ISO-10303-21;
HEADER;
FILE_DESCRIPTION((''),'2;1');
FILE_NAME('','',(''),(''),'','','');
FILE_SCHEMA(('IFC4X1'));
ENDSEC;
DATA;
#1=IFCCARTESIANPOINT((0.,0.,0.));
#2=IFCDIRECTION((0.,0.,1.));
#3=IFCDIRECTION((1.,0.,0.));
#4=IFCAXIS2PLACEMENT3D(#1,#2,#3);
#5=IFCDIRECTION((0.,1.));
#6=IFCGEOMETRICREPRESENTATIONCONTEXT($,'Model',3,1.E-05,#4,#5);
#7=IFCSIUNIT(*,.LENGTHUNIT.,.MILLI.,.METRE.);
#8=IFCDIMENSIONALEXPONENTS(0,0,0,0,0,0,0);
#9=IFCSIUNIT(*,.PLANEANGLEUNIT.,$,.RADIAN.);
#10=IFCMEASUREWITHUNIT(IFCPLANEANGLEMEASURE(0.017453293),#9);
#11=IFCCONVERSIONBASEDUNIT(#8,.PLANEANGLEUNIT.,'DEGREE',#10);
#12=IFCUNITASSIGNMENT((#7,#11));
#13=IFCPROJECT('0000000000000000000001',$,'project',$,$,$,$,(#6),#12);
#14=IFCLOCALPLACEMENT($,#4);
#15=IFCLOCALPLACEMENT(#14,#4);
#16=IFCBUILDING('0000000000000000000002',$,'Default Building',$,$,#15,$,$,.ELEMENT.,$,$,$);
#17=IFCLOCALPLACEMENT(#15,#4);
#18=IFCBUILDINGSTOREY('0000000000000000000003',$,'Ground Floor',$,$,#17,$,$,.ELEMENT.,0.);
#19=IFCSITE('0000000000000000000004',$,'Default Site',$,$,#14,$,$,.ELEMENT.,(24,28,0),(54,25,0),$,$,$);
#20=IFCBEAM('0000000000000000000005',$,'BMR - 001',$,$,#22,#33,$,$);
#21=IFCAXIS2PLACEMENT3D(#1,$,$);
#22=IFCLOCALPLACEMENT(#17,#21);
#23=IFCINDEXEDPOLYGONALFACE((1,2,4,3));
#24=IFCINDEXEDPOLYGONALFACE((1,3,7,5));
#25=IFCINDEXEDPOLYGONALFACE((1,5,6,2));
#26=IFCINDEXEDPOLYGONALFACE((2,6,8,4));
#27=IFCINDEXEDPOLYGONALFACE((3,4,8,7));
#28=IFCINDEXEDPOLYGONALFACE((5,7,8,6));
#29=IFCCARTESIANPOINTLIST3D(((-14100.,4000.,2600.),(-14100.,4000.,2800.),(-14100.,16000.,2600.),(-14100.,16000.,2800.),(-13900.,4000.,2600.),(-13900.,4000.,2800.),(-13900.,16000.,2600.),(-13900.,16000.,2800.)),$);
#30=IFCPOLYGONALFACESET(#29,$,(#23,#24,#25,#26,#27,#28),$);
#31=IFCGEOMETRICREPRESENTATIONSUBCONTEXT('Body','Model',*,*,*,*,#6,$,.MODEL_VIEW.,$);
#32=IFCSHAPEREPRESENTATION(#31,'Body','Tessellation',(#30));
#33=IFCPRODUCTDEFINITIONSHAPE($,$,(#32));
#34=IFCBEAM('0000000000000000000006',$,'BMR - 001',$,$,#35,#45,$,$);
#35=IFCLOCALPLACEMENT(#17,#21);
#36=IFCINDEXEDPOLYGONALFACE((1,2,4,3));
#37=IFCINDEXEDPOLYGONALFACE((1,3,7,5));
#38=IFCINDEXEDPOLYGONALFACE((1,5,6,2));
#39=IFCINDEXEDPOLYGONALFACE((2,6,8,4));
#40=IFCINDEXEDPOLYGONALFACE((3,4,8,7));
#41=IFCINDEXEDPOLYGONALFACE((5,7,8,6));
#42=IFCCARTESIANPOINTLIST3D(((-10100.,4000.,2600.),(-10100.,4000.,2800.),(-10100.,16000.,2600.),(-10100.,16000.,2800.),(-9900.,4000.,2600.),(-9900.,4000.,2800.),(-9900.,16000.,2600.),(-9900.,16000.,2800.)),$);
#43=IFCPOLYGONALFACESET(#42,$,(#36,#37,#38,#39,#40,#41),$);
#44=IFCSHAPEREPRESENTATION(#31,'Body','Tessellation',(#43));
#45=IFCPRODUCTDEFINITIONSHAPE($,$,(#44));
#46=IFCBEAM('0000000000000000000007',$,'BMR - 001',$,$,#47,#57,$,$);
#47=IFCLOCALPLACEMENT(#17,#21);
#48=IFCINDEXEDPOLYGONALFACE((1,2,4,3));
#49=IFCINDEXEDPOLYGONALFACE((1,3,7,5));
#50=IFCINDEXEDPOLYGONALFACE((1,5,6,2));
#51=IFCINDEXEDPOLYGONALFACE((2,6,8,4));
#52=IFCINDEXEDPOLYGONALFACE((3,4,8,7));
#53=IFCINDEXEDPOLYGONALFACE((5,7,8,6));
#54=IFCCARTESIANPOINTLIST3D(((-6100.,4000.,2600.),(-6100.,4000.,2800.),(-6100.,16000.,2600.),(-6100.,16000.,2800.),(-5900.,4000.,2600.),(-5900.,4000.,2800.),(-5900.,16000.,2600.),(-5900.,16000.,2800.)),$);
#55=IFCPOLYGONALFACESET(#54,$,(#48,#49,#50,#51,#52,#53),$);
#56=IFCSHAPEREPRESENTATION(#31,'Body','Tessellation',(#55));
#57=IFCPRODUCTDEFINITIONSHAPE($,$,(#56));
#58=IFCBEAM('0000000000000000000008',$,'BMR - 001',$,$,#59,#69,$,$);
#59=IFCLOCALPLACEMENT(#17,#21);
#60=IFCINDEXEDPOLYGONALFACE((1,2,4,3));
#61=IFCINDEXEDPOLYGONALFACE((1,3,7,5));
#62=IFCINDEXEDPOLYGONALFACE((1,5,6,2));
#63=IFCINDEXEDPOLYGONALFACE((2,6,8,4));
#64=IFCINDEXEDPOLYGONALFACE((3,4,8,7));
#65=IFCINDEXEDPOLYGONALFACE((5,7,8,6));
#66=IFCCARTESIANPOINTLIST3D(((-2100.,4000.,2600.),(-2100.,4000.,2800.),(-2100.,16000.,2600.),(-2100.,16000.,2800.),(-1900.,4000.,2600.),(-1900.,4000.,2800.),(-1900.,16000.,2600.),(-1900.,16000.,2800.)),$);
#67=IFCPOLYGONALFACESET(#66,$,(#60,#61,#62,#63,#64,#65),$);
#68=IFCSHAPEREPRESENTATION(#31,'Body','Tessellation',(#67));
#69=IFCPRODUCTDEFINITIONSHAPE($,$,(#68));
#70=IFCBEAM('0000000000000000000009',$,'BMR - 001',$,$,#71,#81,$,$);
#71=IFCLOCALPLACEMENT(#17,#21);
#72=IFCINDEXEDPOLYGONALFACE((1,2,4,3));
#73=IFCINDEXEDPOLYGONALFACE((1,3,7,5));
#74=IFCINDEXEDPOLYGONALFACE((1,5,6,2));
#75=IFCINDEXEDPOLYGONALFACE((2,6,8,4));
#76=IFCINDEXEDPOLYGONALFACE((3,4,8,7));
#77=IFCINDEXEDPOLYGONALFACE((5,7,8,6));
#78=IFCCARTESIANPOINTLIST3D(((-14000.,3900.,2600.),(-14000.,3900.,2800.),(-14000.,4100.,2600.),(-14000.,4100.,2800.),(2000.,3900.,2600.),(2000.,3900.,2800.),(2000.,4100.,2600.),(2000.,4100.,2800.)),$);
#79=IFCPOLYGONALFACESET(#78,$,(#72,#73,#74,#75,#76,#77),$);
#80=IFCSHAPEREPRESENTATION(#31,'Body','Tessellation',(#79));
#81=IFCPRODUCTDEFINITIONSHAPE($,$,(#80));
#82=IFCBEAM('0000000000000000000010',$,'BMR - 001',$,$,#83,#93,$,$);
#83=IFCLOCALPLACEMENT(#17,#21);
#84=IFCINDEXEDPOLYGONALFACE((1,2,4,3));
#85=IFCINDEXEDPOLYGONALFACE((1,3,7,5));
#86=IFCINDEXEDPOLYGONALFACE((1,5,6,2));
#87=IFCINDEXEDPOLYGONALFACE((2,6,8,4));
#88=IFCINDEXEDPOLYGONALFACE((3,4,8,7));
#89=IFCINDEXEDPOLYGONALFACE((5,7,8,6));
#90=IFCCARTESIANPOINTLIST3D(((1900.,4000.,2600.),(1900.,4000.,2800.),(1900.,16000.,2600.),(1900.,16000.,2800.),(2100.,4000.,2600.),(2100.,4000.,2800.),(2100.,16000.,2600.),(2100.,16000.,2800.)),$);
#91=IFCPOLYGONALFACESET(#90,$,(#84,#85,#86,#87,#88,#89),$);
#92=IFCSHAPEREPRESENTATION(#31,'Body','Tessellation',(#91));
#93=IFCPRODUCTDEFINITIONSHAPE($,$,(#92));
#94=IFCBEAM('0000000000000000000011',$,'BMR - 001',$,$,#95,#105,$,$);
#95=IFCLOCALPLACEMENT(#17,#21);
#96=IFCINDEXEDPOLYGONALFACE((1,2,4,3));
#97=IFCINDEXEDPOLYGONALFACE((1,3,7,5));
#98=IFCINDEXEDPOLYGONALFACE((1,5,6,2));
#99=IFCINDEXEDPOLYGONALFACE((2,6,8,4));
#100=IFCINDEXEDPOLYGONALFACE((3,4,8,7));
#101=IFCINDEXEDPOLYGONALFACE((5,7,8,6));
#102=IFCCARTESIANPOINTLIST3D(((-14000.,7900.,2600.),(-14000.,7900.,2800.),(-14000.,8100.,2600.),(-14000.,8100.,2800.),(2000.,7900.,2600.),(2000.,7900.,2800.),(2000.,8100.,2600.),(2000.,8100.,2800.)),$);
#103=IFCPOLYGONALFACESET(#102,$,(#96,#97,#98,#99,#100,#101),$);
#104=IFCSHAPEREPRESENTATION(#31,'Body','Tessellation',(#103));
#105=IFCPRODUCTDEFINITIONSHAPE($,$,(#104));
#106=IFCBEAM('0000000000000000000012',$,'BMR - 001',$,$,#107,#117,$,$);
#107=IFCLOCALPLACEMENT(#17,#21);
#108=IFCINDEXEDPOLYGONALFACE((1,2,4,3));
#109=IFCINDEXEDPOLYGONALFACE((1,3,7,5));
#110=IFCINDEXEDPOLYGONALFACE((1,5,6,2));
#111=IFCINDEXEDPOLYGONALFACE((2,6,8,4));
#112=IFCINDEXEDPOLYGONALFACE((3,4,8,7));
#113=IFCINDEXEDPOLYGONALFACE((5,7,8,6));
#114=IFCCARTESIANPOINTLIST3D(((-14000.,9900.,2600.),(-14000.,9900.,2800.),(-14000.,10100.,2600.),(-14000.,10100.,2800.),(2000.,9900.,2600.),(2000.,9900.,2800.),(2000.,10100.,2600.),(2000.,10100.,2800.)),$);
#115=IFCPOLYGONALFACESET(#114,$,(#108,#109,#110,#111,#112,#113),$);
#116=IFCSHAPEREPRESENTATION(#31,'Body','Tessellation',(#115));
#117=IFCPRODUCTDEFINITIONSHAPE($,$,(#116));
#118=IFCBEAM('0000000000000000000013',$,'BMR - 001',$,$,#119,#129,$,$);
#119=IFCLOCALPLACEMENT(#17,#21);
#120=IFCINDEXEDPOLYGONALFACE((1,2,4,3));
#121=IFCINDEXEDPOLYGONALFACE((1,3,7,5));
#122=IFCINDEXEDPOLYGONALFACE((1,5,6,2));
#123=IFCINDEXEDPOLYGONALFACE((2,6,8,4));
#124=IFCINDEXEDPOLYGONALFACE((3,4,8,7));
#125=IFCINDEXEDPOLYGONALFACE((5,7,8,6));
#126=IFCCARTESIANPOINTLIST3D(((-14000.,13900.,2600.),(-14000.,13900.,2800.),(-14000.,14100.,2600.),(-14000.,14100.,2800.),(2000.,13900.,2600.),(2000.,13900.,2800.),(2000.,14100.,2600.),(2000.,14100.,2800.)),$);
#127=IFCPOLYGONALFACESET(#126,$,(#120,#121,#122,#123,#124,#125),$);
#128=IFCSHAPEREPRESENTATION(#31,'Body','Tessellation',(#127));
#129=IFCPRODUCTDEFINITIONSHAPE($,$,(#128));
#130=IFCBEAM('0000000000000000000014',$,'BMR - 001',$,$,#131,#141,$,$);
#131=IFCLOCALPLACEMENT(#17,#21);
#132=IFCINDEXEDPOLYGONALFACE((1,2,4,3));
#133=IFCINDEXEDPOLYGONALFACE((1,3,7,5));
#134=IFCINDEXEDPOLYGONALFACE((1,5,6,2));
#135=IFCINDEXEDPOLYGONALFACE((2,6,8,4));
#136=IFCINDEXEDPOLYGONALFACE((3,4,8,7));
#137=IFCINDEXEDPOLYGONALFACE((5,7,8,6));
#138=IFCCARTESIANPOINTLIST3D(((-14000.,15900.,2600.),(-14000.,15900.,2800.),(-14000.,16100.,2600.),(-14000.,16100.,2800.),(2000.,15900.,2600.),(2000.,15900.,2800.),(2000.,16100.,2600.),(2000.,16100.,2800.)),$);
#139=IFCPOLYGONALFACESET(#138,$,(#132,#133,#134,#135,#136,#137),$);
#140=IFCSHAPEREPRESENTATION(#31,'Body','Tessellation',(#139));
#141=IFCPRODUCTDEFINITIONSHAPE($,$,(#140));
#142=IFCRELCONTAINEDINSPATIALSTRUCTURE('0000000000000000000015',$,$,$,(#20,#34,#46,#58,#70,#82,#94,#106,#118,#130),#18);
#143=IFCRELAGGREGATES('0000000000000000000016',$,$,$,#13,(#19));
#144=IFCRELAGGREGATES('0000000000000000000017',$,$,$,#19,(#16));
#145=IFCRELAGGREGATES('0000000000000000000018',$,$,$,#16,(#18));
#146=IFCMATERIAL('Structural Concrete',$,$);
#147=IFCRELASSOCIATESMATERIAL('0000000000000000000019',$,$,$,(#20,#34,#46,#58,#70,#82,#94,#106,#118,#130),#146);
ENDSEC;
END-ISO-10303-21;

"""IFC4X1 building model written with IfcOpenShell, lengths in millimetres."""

from ifc_helpers import new_model, entity, si_unit, converted_unit, direction, frame, frame_2d, origin_with_axes, place, context, subcontext, project, spatial, rectangle, extrude, material, element, save


model = new_model("IFC4X1")

# Units and contexts
model_context = context("Model", 3, precision=1e-05, world=origin_with_axes(), true_north=direction((0.0, 1.0)))
body_context = subcontext(model_context, "Body", "Model", "MODEL_VIEW")
ifc_project = project(units=[si_unit("LENGTHUNIT", "METRE", prefix="MILLI"), converted_unit("PLANEANGLEUNIT", "DEGREE", entity("IfcPlaneAngleMeasure", 0.017453293), si_unit("PLANEANGLEUNIT", "RADIAN"), dimensions=[0, 0, 0, 0, 0, 0, 0])], contexts=[model_context])

# Site, building, storey
site_placement = place(None, origin_with_axes())
site = spatial("IfcSite", under=ifc_project, at=site_placement, Name="Default Site", CompositionType="ELEMENT", RefLatitude=(24, 28, 0), RefLongitude=(54, 25, 0))
building_placement = place(site_placement, origin_with_axes())
building = spatial("IfcBuilding", under=site, at=building_placement, Name="Default Building", CompositionType="ELEMENT")
storey_placement = place(building_placement, origin_with_axes())
storey = spatial("IfcBuildingStorey", under=building, at=storey_placement, Name="Ground Floor", CompositionType="ELEMENT", Elevation=0.0)

# Beams
ifc_material = material(Name="Structural Concrete")
for number, where, z_axis, x_axis, name in (
    (1, (-14000.0, 4000.0, 2800.0), (0.0, 0.0, 1.0), (1.0, 0.0, 0.0), "BMR - 001"),
    (2, (-10000.0, 4000.0, 2800.0), (0.0, 0.0, 1.0), (1.0, 0.0, 0.0), "BMR - 001"),
    (3, (-6000.0, 4000.0, 2800.0), (0.0, 0.0, 1.0), (1.0, 0.0, 0.0), "BMR - 001"),
    (4, (-2000.0, 4000.0, 2800.0), (0.0, 0.0, 1.0), (1.0, 0.0, 0.0), "BMR - 001"),
):
    element("IfcBeam", number, at=place(storey_placement, frame(where, z_axis=z_axis, x_axis=x_axis)), inside=storey, material=ifc_material, Name=name, context=body_context, shape_type="SweptSolid", body=[
        extrude(rectangle(XDim=200.0, YDim=200.0, at=frame_2d((-100.0, 0.0), x_axis=(1.0, 0.0))), frame((0.0, 0.0, 0.0), z_axis=(0.0, 1.0, 0.0), x_axis=(0.0, 0.0, 1.0)), (0.0, 0.0, 1.0), 12000.0),
    ])
beam_1_placement = place(storey_placement, frame((-14000.0, 4000.0, 2800.0), z_axis=(0.0, 0.0, 1.0), x_axis=(0.0, -1.0, 0.0)))
element("IfcBeam", 5, at=beam_1_placement, inside=storey, material=ifc_material, Name="BMR - 001", context=body_context, shape_type="SweptSolid", body=[
    extrude(rectangle(XDim=200.0, YDim=200.0, at=frame_2d((-100.0, 0.0), x_axis=(1.0, 0.0))), frame((0.0, 0.0, 0.0), z_axis=(0.0, 1.0, 0.0), x_axis=(0.0, 0.0, 1.0)), (0.0, 0.0, 1.0), 16000.0),
])
beam_2_placement = place(storey_placement, frame((2000.0, 4000.0, 2800.0), z_axis=(0.0, 0.0, 1.0), x_axis=(1.0, 0.0, 0.0)))
element("IfcBeam", 6, at=beam_2_placement, inside=storey, material=ifc_material, Name="BMR - 001", context=body_context, shape_type="SweptSolid", body=[
    extrude(rectangle(XDim=200.0, YDim=200.0, at=frame_2d((-100.0, 0.0), x_axis=(1.0, 0.0))), frame((0.0, 0.0, 0.0), z_axis=(0.0, 1.0, 0.0), x_axis=(0.0, 0.0, 1.0)), (0.0, 0.0, 1.0), 12000.0),
])
for number, where, z_axis, x_axis, name in (
    (7, (-14000.0, 8000.0, 2800.0), (0.0, 0.0, 1.0), (0.0, -1.0, 0.0), "BMR - 001"),
    (8, (-14000.0, 10000.0, 2800.0), (0.0, 0.0, 1.0), (0.0, -1.0, 0.0), "BMR - 001"),
    (9, (-14000.0, 14000.0, 2800.0), (0.0, 0.0, 1.0), (0.0, -1.0, 0.0), "BMR - 001"),
    (10, (-14000.0, 16000.0, 2800.0), (0.0, 0.0, 1.0), (0.0, -1.0, 0.0), "BMR - 001"),
):
    element("IfcBeam", number, at=place(storey_placement, frame(where, z_axis=z_axis, x_axis=x_axis)), inside=storey, material=ifc_material, Name=name, context=body_context, shape_type="SweptSolid", body=[
        extrude(rectangle(XDim=200.0, YDim=200.0, at=frame_2d((-100.0, 0.0), x_axis=(1.0, 0.0))), frame((0.0, 0.0, 0.0), z_axis=(0.0, 1.0, 0.0), x_axis=(0.0, 0.0, 1.0)), (0.0, 0.0, 1.0), 16000.0),
    ])

save(model, "model.ifc")
